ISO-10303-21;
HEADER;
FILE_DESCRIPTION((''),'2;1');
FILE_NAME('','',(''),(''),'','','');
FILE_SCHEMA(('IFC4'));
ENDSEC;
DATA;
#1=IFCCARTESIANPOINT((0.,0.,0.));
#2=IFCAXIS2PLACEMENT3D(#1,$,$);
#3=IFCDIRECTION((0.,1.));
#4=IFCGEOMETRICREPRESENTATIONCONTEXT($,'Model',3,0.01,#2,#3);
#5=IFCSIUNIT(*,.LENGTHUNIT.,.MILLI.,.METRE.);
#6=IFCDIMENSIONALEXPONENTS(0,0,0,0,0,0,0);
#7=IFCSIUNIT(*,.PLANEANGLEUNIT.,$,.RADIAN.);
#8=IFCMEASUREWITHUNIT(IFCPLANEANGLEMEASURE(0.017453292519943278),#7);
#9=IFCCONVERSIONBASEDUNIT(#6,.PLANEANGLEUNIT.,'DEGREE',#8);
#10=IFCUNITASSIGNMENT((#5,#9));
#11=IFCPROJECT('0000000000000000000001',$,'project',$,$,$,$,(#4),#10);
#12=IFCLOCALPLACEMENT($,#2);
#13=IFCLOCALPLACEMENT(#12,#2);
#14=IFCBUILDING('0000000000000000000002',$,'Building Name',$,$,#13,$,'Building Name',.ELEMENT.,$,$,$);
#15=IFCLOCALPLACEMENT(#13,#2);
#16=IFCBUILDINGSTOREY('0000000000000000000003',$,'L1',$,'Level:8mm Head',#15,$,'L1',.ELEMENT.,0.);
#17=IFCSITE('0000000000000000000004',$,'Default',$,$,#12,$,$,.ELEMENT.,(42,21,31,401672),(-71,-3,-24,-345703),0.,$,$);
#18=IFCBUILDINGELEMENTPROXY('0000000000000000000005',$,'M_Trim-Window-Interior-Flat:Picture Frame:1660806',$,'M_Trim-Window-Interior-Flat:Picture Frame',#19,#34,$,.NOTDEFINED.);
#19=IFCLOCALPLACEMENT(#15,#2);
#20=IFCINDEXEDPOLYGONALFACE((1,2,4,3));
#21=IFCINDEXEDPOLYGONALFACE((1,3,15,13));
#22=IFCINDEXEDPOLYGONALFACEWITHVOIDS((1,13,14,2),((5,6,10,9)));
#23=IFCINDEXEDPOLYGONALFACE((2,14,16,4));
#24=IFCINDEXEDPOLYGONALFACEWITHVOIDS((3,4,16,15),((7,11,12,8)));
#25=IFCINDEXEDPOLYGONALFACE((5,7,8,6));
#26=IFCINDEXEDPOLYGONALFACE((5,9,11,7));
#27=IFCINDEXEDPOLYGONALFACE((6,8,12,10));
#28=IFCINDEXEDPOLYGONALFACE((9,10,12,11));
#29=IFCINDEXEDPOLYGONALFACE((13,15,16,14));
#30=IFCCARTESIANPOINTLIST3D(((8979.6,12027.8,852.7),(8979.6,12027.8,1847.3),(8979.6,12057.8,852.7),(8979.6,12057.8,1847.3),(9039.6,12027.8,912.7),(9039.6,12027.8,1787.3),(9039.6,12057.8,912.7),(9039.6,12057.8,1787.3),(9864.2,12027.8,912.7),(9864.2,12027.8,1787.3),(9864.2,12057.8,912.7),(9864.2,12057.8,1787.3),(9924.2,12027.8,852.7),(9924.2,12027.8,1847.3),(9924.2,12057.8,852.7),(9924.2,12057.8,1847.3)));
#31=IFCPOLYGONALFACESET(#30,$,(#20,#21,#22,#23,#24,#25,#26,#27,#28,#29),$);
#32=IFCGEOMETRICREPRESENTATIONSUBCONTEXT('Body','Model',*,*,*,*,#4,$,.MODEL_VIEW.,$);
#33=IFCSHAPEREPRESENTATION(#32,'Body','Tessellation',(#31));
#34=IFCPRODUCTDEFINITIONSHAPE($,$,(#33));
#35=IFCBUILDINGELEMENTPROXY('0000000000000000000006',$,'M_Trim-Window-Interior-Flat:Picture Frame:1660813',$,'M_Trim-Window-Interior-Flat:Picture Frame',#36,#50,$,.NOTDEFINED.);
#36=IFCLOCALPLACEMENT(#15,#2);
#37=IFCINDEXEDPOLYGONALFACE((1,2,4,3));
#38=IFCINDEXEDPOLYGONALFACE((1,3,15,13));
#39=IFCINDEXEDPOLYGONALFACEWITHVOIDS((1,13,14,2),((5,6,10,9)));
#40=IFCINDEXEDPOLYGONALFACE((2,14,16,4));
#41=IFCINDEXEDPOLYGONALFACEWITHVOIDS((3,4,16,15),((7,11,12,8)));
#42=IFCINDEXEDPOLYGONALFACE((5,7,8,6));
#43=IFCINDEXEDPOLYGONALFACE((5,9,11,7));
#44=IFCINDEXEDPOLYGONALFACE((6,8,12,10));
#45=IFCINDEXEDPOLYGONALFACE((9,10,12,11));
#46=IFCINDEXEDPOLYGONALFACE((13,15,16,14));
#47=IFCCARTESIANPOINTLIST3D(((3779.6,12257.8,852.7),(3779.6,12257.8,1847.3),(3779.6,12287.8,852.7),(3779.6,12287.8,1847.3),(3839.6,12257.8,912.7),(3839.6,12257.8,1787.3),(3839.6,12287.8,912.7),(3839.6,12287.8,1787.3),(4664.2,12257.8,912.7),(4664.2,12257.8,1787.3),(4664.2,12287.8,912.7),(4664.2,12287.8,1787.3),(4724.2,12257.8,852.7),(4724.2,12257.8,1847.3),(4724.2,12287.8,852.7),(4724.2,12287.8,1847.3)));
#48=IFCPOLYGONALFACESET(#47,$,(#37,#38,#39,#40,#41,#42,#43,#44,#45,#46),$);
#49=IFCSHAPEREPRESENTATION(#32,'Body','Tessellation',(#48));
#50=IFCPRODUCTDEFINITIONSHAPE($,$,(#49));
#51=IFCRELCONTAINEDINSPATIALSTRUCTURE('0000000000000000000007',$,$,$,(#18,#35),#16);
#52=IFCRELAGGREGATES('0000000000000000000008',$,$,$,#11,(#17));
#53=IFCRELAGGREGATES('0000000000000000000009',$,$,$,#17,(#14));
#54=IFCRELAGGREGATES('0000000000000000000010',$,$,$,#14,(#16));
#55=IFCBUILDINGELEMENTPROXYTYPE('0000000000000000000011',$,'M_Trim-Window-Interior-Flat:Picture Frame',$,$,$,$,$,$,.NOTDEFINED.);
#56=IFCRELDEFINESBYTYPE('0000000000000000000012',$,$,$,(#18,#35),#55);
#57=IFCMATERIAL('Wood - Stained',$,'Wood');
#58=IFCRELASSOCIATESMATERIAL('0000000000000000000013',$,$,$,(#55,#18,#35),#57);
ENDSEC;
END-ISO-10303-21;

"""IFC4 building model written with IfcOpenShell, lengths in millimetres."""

from ifc_helpers import new_model, entity, si_unit, converted_unit, direction, frame, origin, place, context, subcontext, project, spatial, indexed_curve, outline, extrude, source, transform, mapped, material, type_object, type_shapes, element, save


model = new_model("IFC4")

# Units and contexts
model_context = context("Model", 3, precision=0.01, world=origin(), true_north=direction((0.0, 1.0)))
body_context = subcontext(model_context, "Body", "Model", "MODEL_VIEW")
ifc_project = project(units=[si_unit("LENGTHUNIT", "METRE", prefix="MILLI"), converted_unit("PLANEANGLEUNIT", "DEGREE", entity("IfcPlaneAngleMeasure", 0.017453292519943278), si_unit("PLANEANGLEUNIT", "RADIAN"), dimensions=[0, 0, 0, 0, 0, 0, 0])], contexts=[model_context])

# Site, building, storey
site_placement = place(None, origin())
site = spatial("IfcSite", under=ifc_project, at=site_placement, Name="Default", CompositionType="ELEMENT", RefLatitude=(42, 21, 31, 401672), RefLongitude=(-71, -3, -24, -345703), RefElevation=0.0)
building_placement = place(site_placement, origin())
building = spatial("IfcBuilding", under=site, at=building_placement, Name="Building Name", LongName="Building Name", CompositionType="ELEMENT")
storey_placement = place(building_placement, origin())
storey = spatial("IfcBuildingStorey", under=building, at=storey_placement, Name="L1", ObjectType="Level:8mm Head", LongName="L1", CompositionType="ELEMENT", Elevation=0.0)

# Building element proxies
ifc_material_1 = material(Name="Wood - Stained", Category="Wood")
building_element_proxy_type_1 = type_object("IfcBuildingElementProxyType", Name="M_Trim-Window-Interior-Flat:Picture Frame", PredefinedType="NOTDEFINED", material=ifc_material_1)
shared_shape_1 = source(origin(), body_context, "Body", "SweptSolid", [
    extrude(outline(indexed_curve([(-472.3, -497.3), (472.3, -497.3), (472.3, 497.3), (-472.3, 497.3), (-472.3, -497.3)], self_intersect=False), holes=[indexed_curve([(-412.3, -437.3), (-412.3, 437.3), (412.3, 437.3), (412.3, -437.3), (-412.3, -437.3)], self_intersect=False)]), frame((0.0, -450.0, 0.0), z_axis=(0.0, 0.0, 1.0), x_axis=(-1.0, 0.0, 0.0)), (0.0, 0.0, 1.0), 30.0),
])
type_shapes(building_element_proxy_type_1, [shared_shape_1])
for number, where, z_axis, x_axis, name in (
    (1, (9451.9, 12057.8, 1800.0), (0.0, -1.0, 0.0), (1.0, 0.0, 0.0), "M_Trim-Window-Interior-Flat:Picture Frame:1660806"),
    (2, (4251.9, 12257.8, 1800.0), (0.0, 1.0, 0.0), (-1.0, 0.0, 0.0), "M_Trim-Window-Interior-Flat:Picture Frame:1660813"),
):
    element("IfcBuildingElementProxy", number, at=place(storey_placement, frame(where, z_axis=z_axis, x_axis=x_axis)), inside=storey, type_object=building_element_proxy_type_1, material=ifc_material_1, Name=name, ObjectType="M_Trim-Window-Interior-Flat:Picture Frame", PredefinedType="NOTDEFINED", context=body_context, shape_type="MappedRepresentation", body=[
        mapped(shared_shape_1, transform((0.0, 0.0, 0.0), scale=1.0)),
    ])

save(model, "model.ifc")
